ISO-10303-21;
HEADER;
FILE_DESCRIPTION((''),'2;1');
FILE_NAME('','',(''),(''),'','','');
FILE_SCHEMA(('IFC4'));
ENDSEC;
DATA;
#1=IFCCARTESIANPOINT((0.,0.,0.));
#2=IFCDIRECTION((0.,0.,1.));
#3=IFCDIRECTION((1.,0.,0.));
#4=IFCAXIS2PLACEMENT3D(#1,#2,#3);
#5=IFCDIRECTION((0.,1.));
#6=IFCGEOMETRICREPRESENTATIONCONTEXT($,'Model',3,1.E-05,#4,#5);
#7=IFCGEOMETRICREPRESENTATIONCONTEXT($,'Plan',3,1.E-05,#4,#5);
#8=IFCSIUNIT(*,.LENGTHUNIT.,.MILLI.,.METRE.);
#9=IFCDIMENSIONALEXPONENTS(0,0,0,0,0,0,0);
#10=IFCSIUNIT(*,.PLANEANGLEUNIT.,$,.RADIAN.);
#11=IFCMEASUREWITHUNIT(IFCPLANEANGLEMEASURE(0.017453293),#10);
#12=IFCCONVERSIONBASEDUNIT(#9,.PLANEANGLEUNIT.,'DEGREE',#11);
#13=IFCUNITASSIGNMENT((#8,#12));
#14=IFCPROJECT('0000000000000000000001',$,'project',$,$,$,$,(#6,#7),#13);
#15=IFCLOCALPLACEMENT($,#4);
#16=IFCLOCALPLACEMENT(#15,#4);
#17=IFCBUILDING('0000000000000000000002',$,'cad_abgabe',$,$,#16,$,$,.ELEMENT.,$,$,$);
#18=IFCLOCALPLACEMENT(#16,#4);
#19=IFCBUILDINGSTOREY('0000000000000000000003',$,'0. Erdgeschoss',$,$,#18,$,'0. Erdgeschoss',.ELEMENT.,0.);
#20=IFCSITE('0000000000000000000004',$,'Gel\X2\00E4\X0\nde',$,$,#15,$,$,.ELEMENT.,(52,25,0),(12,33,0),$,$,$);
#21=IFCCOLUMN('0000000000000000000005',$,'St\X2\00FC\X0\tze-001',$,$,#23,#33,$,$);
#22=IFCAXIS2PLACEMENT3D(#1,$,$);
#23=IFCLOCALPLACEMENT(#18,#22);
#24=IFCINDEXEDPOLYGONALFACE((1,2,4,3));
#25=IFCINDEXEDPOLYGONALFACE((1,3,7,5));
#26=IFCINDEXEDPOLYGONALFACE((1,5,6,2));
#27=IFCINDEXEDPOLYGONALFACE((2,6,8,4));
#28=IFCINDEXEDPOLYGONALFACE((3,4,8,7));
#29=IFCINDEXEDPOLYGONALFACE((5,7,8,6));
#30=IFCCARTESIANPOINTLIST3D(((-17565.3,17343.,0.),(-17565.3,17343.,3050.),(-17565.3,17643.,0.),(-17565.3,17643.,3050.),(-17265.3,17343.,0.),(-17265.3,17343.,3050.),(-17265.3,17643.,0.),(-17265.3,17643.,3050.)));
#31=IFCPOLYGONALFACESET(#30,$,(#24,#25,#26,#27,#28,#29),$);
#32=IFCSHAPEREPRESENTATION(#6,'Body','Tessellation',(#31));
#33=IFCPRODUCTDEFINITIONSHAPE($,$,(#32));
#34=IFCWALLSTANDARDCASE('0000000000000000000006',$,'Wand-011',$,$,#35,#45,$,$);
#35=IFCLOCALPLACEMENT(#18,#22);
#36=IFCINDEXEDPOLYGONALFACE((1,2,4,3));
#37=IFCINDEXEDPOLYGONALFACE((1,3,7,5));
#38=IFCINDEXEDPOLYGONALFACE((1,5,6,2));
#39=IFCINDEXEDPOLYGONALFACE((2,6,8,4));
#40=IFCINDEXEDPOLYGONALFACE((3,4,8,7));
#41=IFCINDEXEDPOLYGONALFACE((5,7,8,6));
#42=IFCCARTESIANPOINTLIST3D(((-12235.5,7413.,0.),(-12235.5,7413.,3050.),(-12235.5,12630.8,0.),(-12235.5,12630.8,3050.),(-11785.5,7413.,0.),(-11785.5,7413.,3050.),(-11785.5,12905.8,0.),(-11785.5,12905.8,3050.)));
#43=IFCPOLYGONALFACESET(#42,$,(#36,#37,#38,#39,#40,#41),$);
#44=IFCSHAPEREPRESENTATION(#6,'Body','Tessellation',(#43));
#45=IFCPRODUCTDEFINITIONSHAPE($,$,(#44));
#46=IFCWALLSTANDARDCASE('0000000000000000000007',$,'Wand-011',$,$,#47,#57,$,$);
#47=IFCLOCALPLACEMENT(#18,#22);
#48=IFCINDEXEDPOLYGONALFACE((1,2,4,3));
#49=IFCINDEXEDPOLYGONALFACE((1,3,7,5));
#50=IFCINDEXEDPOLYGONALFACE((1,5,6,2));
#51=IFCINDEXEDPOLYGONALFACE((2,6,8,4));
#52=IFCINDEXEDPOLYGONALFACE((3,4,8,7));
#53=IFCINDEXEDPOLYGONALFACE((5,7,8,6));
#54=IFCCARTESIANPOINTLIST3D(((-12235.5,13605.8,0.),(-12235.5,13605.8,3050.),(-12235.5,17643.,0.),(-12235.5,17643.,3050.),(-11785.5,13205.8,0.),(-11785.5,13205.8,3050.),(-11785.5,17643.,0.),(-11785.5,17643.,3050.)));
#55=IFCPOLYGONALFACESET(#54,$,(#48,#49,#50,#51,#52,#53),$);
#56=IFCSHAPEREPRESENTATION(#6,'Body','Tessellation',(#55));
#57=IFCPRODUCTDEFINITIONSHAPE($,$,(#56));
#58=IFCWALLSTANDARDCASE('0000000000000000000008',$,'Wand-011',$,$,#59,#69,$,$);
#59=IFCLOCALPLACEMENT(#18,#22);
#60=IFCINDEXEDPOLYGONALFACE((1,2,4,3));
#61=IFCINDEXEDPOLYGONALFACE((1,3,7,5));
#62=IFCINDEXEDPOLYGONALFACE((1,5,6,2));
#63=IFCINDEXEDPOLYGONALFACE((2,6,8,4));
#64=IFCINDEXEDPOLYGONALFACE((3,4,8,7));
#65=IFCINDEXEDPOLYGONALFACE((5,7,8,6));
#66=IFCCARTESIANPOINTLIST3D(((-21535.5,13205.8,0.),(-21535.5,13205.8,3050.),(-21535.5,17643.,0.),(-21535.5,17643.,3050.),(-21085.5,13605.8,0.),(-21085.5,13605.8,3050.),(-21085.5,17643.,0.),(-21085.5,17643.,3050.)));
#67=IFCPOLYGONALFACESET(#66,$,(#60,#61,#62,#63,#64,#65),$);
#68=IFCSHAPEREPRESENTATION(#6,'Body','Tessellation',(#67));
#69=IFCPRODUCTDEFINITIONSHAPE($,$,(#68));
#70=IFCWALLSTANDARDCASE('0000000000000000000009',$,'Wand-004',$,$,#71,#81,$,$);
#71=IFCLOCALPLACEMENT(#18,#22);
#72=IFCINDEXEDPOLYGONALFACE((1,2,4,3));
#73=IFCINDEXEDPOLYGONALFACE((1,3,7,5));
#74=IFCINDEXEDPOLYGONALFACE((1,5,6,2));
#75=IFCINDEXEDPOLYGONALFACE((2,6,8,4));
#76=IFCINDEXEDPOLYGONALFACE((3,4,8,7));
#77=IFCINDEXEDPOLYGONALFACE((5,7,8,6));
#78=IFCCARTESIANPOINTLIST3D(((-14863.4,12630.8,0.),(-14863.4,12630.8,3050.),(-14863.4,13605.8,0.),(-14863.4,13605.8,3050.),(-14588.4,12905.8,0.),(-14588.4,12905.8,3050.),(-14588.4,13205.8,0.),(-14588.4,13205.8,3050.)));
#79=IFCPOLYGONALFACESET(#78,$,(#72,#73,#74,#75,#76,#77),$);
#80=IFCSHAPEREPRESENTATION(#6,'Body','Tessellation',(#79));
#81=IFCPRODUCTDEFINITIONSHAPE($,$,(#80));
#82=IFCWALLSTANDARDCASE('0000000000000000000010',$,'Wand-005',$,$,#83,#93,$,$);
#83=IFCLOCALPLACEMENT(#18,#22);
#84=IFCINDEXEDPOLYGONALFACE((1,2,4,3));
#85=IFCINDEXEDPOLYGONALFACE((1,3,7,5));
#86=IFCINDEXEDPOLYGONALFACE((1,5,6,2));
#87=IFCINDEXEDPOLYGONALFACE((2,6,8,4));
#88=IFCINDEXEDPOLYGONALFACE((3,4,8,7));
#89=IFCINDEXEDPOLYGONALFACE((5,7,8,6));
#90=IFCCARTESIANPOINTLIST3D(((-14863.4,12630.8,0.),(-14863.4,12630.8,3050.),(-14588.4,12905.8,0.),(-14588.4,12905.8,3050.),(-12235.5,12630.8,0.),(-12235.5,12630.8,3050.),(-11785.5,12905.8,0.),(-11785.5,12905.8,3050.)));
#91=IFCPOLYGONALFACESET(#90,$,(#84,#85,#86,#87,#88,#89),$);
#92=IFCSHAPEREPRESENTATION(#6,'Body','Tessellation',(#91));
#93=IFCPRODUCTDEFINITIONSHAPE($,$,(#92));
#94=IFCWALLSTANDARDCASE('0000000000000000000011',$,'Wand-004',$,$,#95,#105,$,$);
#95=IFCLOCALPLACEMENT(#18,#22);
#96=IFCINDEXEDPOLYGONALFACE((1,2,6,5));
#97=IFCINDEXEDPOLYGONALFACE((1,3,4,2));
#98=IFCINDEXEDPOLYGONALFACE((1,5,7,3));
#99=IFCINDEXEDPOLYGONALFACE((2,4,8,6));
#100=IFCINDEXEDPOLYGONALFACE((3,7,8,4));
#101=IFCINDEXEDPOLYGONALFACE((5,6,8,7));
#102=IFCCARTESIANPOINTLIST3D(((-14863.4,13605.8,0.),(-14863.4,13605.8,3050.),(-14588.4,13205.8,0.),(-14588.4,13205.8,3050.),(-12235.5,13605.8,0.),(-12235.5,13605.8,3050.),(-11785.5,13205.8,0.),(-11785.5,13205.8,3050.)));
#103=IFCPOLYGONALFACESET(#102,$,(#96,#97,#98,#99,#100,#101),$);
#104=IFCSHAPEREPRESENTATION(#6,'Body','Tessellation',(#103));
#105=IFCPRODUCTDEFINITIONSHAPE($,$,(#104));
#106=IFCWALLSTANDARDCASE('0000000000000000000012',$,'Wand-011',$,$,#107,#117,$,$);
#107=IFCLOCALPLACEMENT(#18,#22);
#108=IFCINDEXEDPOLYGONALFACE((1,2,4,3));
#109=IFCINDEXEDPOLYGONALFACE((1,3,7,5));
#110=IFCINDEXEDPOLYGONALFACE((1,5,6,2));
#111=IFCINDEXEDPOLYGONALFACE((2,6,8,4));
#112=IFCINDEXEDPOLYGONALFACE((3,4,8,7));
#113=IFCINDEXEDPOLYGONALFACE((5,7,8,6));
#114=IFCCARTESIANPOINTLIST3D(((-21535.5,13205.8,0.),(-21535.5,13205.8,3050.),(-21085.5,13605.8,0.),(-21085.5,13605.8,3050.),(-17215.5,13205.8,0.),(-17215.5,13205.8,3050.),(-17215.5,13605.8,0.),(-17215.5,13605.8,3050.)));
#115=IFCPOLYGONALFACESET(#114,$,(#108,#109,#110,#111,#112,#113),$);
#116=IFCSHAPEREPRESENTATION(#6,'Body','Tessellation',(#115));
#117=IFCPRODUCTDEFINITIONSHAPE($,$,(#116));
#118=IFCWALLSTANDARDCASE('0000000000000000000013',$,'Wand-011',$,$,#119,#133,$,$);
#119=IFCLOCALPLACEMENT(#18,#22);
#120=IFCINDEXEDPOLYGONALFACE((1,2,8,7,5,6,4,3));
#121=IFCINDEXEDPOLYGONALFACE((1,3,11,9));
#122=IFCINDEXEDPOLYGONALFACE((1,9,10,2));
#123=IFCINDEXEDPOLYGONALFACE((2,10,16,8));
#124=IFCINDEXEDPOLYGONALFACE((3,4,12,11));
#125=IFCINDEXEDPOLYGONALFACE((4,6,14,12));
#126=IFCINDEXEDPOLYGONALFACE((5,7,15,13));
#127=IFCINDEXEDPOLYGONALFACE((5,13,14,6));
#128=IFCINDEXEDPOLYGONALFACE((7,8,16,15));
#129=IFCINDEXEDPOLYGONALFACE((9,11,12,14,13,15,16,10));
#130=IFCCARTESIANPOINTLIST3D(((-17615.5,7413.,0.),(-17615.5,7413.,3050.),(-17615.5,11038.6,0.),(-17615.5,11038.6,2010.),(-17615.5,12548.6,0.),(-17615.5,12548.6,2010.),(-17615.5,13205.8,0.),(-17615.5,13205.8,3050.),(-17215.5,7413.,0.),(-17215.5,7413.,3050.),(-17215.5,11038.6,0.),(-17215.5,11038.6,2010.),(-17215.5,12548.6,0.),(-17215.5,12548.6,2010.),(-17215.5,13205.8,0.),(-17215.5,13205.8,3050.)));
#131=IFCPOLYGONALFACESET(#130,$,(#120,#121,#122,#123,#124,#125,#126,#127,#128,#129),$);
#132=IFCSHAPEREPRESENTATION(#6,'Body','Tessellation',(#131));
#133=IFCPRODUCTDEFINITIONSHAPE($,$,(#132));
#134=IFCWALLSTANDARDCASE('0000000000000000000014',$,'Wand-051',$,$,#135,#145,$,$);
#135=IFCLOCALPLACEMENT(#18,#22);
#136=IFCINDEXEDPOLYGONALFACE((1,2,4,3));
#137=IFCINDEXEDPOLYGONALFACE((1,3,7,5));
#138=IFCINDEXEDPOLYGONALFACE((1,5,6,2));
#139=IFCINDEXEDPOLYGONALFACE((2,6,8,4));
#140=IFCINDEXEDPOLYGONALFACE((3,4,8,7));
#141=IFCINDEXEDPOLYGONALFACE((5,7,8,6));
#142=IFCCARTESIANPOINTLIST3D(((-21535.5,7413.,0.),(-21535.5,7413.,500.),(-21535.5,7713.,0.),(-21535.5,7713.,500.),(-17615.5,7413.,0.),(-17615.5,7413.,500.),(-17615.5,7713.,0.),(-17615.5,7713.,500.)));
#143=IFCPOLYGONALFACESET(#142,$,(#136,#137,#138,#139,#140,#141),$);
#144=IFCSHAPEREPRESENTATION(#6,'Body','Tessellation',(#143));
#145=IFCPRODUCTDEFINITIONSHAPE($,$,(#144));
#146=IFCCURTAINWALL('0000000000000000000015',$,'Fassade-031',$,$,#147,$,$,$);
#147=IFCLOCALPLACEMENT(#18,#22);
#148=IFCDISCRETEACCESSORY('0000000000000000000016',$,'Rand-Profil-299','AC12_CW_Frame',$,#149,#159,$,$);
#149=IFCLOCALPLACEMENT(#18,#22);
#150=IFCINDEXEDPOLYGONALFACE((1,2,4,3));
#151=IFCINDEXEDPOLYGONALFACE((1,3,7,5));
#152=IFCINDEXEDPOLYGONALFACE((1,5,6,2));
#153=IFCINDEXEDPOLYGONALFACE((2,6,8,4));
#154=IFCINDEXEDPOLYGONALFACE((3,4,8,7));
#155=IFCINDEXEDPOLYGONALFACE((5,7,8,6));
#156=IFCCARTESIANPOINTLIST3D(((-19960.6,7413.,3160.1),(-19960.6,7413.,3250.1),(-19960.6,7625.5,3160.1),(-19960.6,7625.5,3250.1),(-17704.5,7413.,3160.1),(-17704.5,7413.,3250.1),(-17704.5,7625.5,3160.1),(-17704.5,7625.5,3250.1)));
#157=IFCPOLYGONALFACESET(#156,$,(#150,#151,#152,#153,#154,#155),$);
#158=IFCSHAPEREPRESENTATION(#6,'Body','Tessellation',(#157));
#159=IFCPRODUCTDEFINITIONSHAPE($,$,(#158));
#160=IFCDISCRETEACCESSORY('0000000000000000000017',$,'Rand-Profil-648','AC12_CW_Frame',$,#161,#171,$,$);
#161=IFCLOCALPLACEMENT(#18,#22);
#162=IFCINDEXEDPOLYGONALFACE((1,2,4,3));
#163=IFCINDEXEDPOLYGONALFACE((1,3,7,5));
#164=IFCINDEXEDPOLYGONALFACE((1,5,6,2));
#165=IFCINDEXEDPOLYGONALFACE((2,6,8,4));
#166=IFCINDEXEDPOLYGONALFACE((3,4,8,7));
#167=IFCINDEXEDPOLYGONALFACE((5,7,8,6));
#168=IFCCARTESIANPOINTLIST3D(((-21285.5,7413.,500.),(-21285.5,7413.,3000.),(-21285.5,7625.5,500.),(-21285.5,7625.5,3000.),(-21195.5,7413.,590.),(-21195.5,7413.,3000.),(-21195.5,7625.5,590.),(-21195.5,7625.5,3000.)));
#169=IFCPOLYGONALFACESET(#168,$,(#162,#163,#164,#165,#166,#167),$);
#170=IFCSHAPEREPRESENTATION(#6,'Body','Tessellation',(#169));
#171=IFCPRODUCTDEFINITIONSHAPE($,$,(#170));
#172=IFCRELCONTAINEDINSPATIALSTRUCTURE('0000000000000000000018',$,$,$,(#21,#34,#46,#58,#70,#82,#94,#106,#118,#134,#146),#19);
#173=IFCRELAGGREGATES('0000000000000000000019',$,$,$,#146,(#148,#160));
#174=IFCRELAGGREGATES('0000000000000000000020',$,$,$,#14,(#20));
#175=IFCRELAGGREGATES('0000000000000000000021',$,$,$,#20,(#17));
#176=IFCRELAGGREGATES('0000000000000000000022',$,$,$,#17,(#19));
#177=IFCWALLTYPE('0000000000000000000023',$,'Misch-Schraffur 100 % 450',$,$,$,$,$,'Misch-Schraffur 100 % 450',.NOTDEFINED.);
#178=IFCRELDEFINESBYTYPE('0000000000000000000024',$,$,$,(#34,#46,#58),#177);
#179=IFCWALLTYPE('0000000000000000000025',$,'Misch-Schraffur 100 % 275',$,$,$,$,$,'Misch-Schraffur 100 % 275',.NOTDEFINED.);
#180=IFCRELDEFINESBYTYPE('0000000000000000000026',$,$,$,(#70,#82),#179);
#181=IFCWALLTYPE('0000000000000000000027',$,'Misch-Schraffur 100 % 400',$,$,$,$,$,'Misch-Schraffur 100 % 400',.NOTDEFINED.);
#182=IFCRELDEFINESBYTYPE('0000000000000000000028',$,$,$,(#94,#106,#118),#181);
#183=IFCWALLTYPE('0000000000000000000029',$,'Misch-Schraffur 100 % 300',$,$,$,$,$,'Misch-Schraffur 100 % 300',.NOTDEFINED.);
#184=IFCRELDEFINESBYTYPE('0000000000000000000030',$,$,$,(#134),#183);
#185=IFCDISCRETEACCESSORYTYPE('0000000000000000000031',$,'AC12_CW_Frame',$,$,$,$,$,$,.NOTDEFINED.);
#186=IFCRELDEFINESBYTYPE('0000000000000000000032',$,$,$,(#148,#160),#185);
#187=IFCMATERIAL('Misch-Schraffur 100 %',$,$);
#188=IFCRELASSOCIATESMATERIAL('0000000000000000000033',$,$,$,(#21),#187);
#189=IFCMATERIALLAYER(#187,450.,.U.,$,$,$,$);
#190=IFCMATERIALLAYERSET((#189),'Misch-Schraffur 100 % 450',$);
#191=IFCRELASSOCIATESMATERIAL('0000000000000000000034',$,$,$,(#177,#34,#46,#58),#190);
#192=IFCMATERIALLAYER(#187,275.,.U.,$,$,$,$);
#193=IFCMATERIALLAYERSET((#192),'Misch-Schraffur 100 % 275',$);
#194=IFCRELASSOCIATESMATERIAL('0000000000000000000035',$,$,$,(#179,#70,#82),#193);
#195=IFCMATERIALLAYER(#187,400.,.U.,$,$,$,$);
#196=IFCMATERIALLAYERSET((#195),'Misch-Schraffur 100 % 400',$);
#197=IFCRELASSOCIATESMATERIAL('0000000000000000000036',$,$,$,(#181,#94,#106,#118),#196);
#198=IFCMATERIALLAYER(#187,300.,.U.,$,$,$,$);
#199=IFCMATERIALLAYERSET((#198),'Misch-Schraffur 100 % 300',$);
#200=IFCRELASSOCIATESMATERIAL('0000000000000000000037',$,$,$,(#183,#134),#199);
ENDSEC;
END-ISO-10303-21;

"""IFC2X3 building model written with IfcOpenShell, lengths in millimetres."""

from ifc_helpers import new_model, entity, si_unit, converted_unit, direction, frame, frame_2d, origin_with_axes, origin_2d_with_axis, place, context, project, spatial, polyline, rectangle, outline, extrude, source, transform, mapped, material, layer, layer_set, layer_usage, type_object, element, aggregate, save


model = new_model("IFC2X3")

# Units and contexts
model_context = context("Model", 3, precision=1e-05, world=origin_with_axes(), true_north=direction((0.0, 1.0)))
plan_context = context("Plan", 3, precision=1e-05, world=origin_with_axes(), true_north=direction((0.0, 1.0)))
ifc_project = project(units=[si_unit("LENGTHUNIT", "METRE", prefix="MILLI"), converted_unit("PLANEANGLEUNIT", "DEGREE", entity("IfcPlaneAngleMeasure", 0.017453293), si_unit("PLANEANGLEUNIT", "RADIAN"), dimensions=[0, 0, 0, 0, 0, 0, 0])], contexts=[model_context, plan_context])

# Site, building, storey
site_placement = place(None, origin_with_axes())
site = spatial("IfcSite", under=ifc_project, at=site_placement, Name="Gelände", CompositionType="ELEMENT", RefLatitude=(52, 25, 0), RefLongitude=(12, 33, 0))
building_placement = place(site_placement, origin_with_axes())
building = spatial("IfcBuilding", under=site, at=building_placement, Name="cad_abgabe", CompositionType="ELEMENT")
storey_placement = place(building_placement, origin_with_axes())
storey = spatial("IfcBuildingStorey", under=building, at=storey_placement, Name="0. Erdgeschoss", LongName="0. Erdgeschoss", CompositionType="ELEMENT", Elevation=0.0)

# Column
ifc_material = material(Name="Misch-Schraffur 100 %")
column_placement = place(storey_placement, frame((-17415.3, 17493.0, 0.0), z_axis=(0.0, 0.0, 1.0), x_axis=(1.0, 0.0, 0.0)))
element("IfcColumn", 1, at=column_placement, inside=storey, material=ifc_material, Name="Stütze-001", context=model_context, shape_type="SweptSolid", body=[
    extrude(rectangle(XDim=300.0, YDim=300.0, at=origin_2d_with_axis()), origin_with_axes(), (0.0, 0.0, 1.0), 3050.0),
])

# Walls
ifc_layer_1 = layer(ifc_material, 450.0, ventilated="UNKNOWN")
ifc_layer_set_1 = layer_set([ifc_layer_1], Name="Misch-Schraffur 100 % 450")
ifc_layer_usage_1 = layer_usage(ifc_layer_set_1, "AXIS2", "POSITIVE", 0.0)
wall_type_1 = type_object("IfcWallType", Name="Misch-Schraffur 100 % 450", ElementType="Misch-Schraffur 100 % 450", PredefinedType="NOTDEFINED", material=ifc_layer_set_1)
wall_1_placement = place(storey_placement, frame((-11785.5, 7413.0, 0.0), z_axis=(0.0, 0.0, 1.0), x_axis=(0.0, 1.0, 0.0)))
element("IfcWallStandardCase", 2, at=wall_1_placement, inside=storey, type_object=wall_type_1, material=ifc_layer_usage_1, Name="Wand-011", context=model_context, shape_type="SweptSolid", body=[
    extrude(outline(polyline([(0.0, 0.0), (5492.8, 0.0), (5217.8, 450.0), (0.0, 450.0), (0.0, 0.0)])), origin_with_axes(), (0.0, 0.0, 1.0), 3050.0),
])
ifc_layer_usage_2 = layer_usage(ifc_layer_set_1, "AXIS2", "POSITIVE", 0.0)
wall_2_placement = place(storey_placement, frame((-11785.5, 13205.8, 0.0), z_axis=(0.0, 0.0, 1.0), x_axis=(0.0, 1.0, 0.0)))
element("IfcWallStandardCase", 3, at=wall_2_placement, inside=storey, type_object=wall_type_1, material=ifc_layer_usage_2, Name="Wand-011", context=model_context, shape_type="SweptSolid", body=[
    extrude(outline(polyline([(0.0, 0.0), (4437.2, 0.0), (4437.2, 450.0), (400.0, 450.0), (0.0, 0.0)])), origin_with_axes(), (0.0, 0.0, 1.0), 3050.0),
])
ifc_layer_usage_3 = layer_usage(ifc_layer_set_1, "AXIS2", "POSITIVE", 0.0)
wall_3_placement = place(storey_placement, frame((-21535.5, 17643.0, 0.0), z_axis=(0.0, 0.0, 1.0), x_axis=(0.0, -1.0, 0.0)))
element("IfcWallStandardCase", 4, at=wall_3_placement, inside=storey, type_object=wall_type_1, material=ifc_layer_usage_3, Name="Wand-011", context=model_context, shape_type="SweptSolid", body=[
    extrude(outline(polyline([(0.0, 0.0), (4437.2, 0.0), (4037.2, 450.0), (0.0, 450.0), (0.0, 0.0)])), origin_with_axes(), (0.0, 0.0, 1.0), 3050.0),
])
ifc_layer_2 = layer(ifc_material, 275.0, ventilated="UNKNOWN")
ifc_layer_set_2 = layer_set([ifc_layer_2], Name="Misch-Schraffur 100 % 275")
ifc_layer_usage_4 = layer_usage(ifc_layer_set_2, "AXIS2", "POSITIVE", 0.0)
wall_type_2 = type_object("IfcWallType", Name="Misch-Schraffur 100 % 275", ElementType="Misch-Schraffur 100 % 275", PredefinedType="NOTDEFINED", material=ifc_layer_set_2)
wall_4_placement = place(storey_placement, frame((-14863.4, 13205.8, 0.0), z_axis=(0.0, 0.0, 1.0), x_axis=(-0.000002, -1.0, 0.0)))
element("IfcWallStandardCase", 5, at=wall_4_placement, inside=storey, type_object=wall_type_2, material=ifc_layer_usage_4, Name="Wand-004", context=model_context, shape_type="SweptSolid", body=[
    extrude(outline(polyline([(-400.0, 0.0), (575.0, 0.0), (300.0, 275.0), (0.0, 275.0), (-400.0, 0.0)])), origin_with_axes(), (0.0, 0.0, 1.0), 3050.0),
])
ifc_layer_usage_5 = layer_usage(ifc_layer_set_2, "AXIS2", "POSITIVE", 0.0)
wall_5_placement = place(storey_placement, frame((-14863.4, 12630.8, 0.0), z_axis=(0.0, 0.0, 1.0), x_axis=(1.0, -0.000002, 0.0)))
element("IfcWallStandardCase", 6, at=wall_5_placement, inside=storey, type_object=wall_type_2, material=ifc_layer_usage_5, Name="Wand-005", context=model_context, shape_type="SweptSolid", body=[
    extrude(outline(polyline([(0.0, 0.0), (2627.9, 0.0), (3077.9, 275.0), (275.0, 275.0), (0.0, 0.0)])), origin_with_axes(), (0.0, 0.0, 1.0), 3050.0),
])
ifc_layer_3 = layer(ifc_material, 400.0, ventilated="UNKNOWN")
ifc_layer_set_3 = layer_set([ifc_layer_3], Name="Misch-Schraffur 100 % 400")
ifc_layer_usage_6 = layer_usage(ifc_layer_set_3, "AXIS2", "NEGATIVE", 0.0)
wall_type_3 = type_object("IfcWallType", Name="Misch-Schraffur 100 % 400", ElementType="Misch-Schraffur 100 % 400", PredefinedType="NOTDEFINED", material=ifc_layer_set_3)
wall_6_placement = place(storey_placement, frame((-11785.5, 13205.8, 0.0), z_axis=(0.0, 0.0, 1.0), x_axis=(-1.0, 0.0, 0.0)))
element("IfcWallStandardCase", 7, at=wall_6_placement, inside=storey, type_object=wall_type_3, material=ifc_layer_usage_6, Name="Wand-004", context=model_context, shape_type="SweptSolid", body=[
    extrude(outline(polyline([(450.0, -400.0), (3077.9, -400.0), (2802.9, 0.0), (0.0, 0.0), (450.0, -400.0)])), origin_with_axes(), (0.0, 0.0, 1.0), 3050.0),
])
ifc_layer_usage_7 = layer_usage(ifc_layer_set_3, "AXIS2", "NEGATIVE", 0.0)
wall_7_placement = place(storey_placement, frame((-21535.5, 13605.8, 0.0), z_axis=(0.0, 0.0, 1.0), x_axis=(1.0, 0.0, 0.0)))
element("IfcWallStandardCase", 8, at=wall_7_placement, inside=storey, type_object=wall_type_3, material=ifc_layer_usage_7, Name="Wand-011", context=model_context, shape_type="SweptSolid", body=[
    extrude(outline(polyline([(0.0, -400.0), (4320.0, -400.0), (4320.0, 0.0), (450.0, 0.0), (0.0, -400.0)])), origin_with_axes(), (0.0, 0.0, 1.0), 3050.0),
])

# Wall, opening
ifc_layer_usage_8 = layer_usage(ifc_layer_set_3, "AXIS2", "NEGATIVE", 0.0)
wall_8_placement = place(storey_placement, frame((-17615.5, 7413.0, 0.0), z_axis=(0.0, 0.0, 1.0), x_axis=(0.0, 1.0, 0.0)))
wall_8 = element("IfcWallStandardCase", 9, at=wall_8_placement, inside=storey, type_object=wall_type_3, material=ifc_layer_usage_8, Name="Wand-011", context=model_context, shape_type="SweptSolid", body=[
    extrude(outline(polyline([(0.0, -400.0), (5792.8, -400.0), (5792.8, 0.0), (0.0, 0.0), (0.0, -400.0)])), origin_with_axes(), (0.0, 0.0, 1.0), 3050.0),
])
opening_placement = place(wall_8_placement, frame((4380.6, -400.0, 0.0), z_axis=(0.0, 0.0, 1.0), x_axis=(1.0, 0.0, 0.0)))
element("IfcOpeningElement", 10, at=opening_placement, cuts=wall_8, ObjectType="Opening", context=model_context, shape_type="SweptSolid", body=[
    extrude(rectangle(XDim=1510.0, YDim=2010.0, at=frame_2d((0.0, 1005.0), x_axis=(-1.0, 0.0))), frame((0.0, 0.0, 0.0), z_axis=(0.0, 1.0, 0.0), x_axis=(-1.0, 0.0, 0.0)), (0.0, 0.0, 1.0), 400.0),
])

# Wall
ifc_layer_4 = layer(ifc_material, 300.0, ventilated="UNKNOWN")
ifc_layer_set_4 = layer_set([ifc_layer_4], Name="Misch-Schraffur 100 % 300")
ifc_layer_usage_9 = layer_usage(ifc_layer_set_4, "AXIS2", "NEGATIVE", 0.0)
wall_type_4 = type_object("IfcWallType", Name="Misch-Schraffur 100 % 300", ElementType="Misch-Schraffur 100 % 300", PredefinedType="NOTDEFINED", material=ifc_layer_set_4)
wall_9_placement = place(storey_placement, frame((-21535.5, 7713.0, 0.0), z_axis=(0.0, 0.0, 1.0), x_axis=(1.0, 0.000003, 0.0)))
element("IfcWallStandardCase", 11, at=wall_9_placement, inside=storey, type_object=wall_type_4, material=ifc_layer_usage_9, Name="Wand-051", context=model_context, shape_type="SweptSolid", body=[
    extrude(outline(polyline([(0.0, -300.0), (3920.0, -300.0), (3920.0, 0.0), (0.0, 0.0), (0.0, -300.0)])), origin_with_axes(), (0.0, 0.0, 1.0), 500.0),
])

# Curtain wall, discrete accessories
curtain_wall_placement = place(storey_placement, frame((-17614.5, 7448.0, 500.0), z_axis=(0.0, 0.0, 1.0), x_axis=(-1.0, 0.0, 0.0)))
curtain_wall = element("IfcCurtainWall", 12, at=curtain_wall_placement, inside=storey, Name="Fassade-031")
discrete_accessory_type = type_object("IfcDiscreteAccessoryType", Name="AC12_CW_Frame")
shared_shape_1 = source(origin_with_axes(), model_context, "Body", "SweptSolid", [
    extrude(outline(polyline([(0.0, 0.0), (2256.1, 0.0), (2256.1, -212.5), (0.0, -212.5), (0.0, 0.0)])), origin_with_axes(), (0.0, 0.0, 1.0), 90.0),
])
discrete_accessory_1_placement = place(storey_placement, frame((-17704.5, 7625.5, 3250.1), z_axis=(0.0, 0.0, -1.0), x_axis=(-1.0, 0.0, 0.0)))
discrete_accessory_1 = element("IfcDiscreteAccessory", 13, at=discrete_accessory_1_placement, type_object=discrete_accessory_type, Name="Rand-Profil-299", Description="AC12_CW_Frame", context=model_context, shape_type="MappedRepresentation", body=[
    mapped(shared_shape_1, transform((0.0, 0.0, 0.0), scale=1.0)),
])
shared_shape_2 = source(origin_with_axes(), model_context, "Body", "SweptSolid", [
    extrude(outline(polyline([(0.0, 0.0), (2500.0, 0.0), (2500.0, -90.0), (90.0, -90.0), (0.0, 0.0)])), origin_with_axes(), (0.0, 0.0, 1.0), 212.5),
])
discrete_accessory_2_placement = place(storey_placement, frame((-21285.5, 7625.5, 500.0), z_axis=(0.0, -1.0, 0.0), x_axis=(0.0, 0.0, 1.0)))
discrete_accessory_2 = element("IfcDiscreteAccessory", 14, at=discrete_accessory_2_placement, type_object=discrete_accessory_type, Name="Rand-Profil-648", Description="AC12_CW_Frame", context=model_context, shape_type="MappedRepresentation", body=[
    mapped(shared_shape_2, transform((0.0, 0.0, 0.0), scale=1.0)),
])
aggregate(curtain_wall, [discrete_accessory_1, discrete_accessory_2])

save(model, "model.ifc")
